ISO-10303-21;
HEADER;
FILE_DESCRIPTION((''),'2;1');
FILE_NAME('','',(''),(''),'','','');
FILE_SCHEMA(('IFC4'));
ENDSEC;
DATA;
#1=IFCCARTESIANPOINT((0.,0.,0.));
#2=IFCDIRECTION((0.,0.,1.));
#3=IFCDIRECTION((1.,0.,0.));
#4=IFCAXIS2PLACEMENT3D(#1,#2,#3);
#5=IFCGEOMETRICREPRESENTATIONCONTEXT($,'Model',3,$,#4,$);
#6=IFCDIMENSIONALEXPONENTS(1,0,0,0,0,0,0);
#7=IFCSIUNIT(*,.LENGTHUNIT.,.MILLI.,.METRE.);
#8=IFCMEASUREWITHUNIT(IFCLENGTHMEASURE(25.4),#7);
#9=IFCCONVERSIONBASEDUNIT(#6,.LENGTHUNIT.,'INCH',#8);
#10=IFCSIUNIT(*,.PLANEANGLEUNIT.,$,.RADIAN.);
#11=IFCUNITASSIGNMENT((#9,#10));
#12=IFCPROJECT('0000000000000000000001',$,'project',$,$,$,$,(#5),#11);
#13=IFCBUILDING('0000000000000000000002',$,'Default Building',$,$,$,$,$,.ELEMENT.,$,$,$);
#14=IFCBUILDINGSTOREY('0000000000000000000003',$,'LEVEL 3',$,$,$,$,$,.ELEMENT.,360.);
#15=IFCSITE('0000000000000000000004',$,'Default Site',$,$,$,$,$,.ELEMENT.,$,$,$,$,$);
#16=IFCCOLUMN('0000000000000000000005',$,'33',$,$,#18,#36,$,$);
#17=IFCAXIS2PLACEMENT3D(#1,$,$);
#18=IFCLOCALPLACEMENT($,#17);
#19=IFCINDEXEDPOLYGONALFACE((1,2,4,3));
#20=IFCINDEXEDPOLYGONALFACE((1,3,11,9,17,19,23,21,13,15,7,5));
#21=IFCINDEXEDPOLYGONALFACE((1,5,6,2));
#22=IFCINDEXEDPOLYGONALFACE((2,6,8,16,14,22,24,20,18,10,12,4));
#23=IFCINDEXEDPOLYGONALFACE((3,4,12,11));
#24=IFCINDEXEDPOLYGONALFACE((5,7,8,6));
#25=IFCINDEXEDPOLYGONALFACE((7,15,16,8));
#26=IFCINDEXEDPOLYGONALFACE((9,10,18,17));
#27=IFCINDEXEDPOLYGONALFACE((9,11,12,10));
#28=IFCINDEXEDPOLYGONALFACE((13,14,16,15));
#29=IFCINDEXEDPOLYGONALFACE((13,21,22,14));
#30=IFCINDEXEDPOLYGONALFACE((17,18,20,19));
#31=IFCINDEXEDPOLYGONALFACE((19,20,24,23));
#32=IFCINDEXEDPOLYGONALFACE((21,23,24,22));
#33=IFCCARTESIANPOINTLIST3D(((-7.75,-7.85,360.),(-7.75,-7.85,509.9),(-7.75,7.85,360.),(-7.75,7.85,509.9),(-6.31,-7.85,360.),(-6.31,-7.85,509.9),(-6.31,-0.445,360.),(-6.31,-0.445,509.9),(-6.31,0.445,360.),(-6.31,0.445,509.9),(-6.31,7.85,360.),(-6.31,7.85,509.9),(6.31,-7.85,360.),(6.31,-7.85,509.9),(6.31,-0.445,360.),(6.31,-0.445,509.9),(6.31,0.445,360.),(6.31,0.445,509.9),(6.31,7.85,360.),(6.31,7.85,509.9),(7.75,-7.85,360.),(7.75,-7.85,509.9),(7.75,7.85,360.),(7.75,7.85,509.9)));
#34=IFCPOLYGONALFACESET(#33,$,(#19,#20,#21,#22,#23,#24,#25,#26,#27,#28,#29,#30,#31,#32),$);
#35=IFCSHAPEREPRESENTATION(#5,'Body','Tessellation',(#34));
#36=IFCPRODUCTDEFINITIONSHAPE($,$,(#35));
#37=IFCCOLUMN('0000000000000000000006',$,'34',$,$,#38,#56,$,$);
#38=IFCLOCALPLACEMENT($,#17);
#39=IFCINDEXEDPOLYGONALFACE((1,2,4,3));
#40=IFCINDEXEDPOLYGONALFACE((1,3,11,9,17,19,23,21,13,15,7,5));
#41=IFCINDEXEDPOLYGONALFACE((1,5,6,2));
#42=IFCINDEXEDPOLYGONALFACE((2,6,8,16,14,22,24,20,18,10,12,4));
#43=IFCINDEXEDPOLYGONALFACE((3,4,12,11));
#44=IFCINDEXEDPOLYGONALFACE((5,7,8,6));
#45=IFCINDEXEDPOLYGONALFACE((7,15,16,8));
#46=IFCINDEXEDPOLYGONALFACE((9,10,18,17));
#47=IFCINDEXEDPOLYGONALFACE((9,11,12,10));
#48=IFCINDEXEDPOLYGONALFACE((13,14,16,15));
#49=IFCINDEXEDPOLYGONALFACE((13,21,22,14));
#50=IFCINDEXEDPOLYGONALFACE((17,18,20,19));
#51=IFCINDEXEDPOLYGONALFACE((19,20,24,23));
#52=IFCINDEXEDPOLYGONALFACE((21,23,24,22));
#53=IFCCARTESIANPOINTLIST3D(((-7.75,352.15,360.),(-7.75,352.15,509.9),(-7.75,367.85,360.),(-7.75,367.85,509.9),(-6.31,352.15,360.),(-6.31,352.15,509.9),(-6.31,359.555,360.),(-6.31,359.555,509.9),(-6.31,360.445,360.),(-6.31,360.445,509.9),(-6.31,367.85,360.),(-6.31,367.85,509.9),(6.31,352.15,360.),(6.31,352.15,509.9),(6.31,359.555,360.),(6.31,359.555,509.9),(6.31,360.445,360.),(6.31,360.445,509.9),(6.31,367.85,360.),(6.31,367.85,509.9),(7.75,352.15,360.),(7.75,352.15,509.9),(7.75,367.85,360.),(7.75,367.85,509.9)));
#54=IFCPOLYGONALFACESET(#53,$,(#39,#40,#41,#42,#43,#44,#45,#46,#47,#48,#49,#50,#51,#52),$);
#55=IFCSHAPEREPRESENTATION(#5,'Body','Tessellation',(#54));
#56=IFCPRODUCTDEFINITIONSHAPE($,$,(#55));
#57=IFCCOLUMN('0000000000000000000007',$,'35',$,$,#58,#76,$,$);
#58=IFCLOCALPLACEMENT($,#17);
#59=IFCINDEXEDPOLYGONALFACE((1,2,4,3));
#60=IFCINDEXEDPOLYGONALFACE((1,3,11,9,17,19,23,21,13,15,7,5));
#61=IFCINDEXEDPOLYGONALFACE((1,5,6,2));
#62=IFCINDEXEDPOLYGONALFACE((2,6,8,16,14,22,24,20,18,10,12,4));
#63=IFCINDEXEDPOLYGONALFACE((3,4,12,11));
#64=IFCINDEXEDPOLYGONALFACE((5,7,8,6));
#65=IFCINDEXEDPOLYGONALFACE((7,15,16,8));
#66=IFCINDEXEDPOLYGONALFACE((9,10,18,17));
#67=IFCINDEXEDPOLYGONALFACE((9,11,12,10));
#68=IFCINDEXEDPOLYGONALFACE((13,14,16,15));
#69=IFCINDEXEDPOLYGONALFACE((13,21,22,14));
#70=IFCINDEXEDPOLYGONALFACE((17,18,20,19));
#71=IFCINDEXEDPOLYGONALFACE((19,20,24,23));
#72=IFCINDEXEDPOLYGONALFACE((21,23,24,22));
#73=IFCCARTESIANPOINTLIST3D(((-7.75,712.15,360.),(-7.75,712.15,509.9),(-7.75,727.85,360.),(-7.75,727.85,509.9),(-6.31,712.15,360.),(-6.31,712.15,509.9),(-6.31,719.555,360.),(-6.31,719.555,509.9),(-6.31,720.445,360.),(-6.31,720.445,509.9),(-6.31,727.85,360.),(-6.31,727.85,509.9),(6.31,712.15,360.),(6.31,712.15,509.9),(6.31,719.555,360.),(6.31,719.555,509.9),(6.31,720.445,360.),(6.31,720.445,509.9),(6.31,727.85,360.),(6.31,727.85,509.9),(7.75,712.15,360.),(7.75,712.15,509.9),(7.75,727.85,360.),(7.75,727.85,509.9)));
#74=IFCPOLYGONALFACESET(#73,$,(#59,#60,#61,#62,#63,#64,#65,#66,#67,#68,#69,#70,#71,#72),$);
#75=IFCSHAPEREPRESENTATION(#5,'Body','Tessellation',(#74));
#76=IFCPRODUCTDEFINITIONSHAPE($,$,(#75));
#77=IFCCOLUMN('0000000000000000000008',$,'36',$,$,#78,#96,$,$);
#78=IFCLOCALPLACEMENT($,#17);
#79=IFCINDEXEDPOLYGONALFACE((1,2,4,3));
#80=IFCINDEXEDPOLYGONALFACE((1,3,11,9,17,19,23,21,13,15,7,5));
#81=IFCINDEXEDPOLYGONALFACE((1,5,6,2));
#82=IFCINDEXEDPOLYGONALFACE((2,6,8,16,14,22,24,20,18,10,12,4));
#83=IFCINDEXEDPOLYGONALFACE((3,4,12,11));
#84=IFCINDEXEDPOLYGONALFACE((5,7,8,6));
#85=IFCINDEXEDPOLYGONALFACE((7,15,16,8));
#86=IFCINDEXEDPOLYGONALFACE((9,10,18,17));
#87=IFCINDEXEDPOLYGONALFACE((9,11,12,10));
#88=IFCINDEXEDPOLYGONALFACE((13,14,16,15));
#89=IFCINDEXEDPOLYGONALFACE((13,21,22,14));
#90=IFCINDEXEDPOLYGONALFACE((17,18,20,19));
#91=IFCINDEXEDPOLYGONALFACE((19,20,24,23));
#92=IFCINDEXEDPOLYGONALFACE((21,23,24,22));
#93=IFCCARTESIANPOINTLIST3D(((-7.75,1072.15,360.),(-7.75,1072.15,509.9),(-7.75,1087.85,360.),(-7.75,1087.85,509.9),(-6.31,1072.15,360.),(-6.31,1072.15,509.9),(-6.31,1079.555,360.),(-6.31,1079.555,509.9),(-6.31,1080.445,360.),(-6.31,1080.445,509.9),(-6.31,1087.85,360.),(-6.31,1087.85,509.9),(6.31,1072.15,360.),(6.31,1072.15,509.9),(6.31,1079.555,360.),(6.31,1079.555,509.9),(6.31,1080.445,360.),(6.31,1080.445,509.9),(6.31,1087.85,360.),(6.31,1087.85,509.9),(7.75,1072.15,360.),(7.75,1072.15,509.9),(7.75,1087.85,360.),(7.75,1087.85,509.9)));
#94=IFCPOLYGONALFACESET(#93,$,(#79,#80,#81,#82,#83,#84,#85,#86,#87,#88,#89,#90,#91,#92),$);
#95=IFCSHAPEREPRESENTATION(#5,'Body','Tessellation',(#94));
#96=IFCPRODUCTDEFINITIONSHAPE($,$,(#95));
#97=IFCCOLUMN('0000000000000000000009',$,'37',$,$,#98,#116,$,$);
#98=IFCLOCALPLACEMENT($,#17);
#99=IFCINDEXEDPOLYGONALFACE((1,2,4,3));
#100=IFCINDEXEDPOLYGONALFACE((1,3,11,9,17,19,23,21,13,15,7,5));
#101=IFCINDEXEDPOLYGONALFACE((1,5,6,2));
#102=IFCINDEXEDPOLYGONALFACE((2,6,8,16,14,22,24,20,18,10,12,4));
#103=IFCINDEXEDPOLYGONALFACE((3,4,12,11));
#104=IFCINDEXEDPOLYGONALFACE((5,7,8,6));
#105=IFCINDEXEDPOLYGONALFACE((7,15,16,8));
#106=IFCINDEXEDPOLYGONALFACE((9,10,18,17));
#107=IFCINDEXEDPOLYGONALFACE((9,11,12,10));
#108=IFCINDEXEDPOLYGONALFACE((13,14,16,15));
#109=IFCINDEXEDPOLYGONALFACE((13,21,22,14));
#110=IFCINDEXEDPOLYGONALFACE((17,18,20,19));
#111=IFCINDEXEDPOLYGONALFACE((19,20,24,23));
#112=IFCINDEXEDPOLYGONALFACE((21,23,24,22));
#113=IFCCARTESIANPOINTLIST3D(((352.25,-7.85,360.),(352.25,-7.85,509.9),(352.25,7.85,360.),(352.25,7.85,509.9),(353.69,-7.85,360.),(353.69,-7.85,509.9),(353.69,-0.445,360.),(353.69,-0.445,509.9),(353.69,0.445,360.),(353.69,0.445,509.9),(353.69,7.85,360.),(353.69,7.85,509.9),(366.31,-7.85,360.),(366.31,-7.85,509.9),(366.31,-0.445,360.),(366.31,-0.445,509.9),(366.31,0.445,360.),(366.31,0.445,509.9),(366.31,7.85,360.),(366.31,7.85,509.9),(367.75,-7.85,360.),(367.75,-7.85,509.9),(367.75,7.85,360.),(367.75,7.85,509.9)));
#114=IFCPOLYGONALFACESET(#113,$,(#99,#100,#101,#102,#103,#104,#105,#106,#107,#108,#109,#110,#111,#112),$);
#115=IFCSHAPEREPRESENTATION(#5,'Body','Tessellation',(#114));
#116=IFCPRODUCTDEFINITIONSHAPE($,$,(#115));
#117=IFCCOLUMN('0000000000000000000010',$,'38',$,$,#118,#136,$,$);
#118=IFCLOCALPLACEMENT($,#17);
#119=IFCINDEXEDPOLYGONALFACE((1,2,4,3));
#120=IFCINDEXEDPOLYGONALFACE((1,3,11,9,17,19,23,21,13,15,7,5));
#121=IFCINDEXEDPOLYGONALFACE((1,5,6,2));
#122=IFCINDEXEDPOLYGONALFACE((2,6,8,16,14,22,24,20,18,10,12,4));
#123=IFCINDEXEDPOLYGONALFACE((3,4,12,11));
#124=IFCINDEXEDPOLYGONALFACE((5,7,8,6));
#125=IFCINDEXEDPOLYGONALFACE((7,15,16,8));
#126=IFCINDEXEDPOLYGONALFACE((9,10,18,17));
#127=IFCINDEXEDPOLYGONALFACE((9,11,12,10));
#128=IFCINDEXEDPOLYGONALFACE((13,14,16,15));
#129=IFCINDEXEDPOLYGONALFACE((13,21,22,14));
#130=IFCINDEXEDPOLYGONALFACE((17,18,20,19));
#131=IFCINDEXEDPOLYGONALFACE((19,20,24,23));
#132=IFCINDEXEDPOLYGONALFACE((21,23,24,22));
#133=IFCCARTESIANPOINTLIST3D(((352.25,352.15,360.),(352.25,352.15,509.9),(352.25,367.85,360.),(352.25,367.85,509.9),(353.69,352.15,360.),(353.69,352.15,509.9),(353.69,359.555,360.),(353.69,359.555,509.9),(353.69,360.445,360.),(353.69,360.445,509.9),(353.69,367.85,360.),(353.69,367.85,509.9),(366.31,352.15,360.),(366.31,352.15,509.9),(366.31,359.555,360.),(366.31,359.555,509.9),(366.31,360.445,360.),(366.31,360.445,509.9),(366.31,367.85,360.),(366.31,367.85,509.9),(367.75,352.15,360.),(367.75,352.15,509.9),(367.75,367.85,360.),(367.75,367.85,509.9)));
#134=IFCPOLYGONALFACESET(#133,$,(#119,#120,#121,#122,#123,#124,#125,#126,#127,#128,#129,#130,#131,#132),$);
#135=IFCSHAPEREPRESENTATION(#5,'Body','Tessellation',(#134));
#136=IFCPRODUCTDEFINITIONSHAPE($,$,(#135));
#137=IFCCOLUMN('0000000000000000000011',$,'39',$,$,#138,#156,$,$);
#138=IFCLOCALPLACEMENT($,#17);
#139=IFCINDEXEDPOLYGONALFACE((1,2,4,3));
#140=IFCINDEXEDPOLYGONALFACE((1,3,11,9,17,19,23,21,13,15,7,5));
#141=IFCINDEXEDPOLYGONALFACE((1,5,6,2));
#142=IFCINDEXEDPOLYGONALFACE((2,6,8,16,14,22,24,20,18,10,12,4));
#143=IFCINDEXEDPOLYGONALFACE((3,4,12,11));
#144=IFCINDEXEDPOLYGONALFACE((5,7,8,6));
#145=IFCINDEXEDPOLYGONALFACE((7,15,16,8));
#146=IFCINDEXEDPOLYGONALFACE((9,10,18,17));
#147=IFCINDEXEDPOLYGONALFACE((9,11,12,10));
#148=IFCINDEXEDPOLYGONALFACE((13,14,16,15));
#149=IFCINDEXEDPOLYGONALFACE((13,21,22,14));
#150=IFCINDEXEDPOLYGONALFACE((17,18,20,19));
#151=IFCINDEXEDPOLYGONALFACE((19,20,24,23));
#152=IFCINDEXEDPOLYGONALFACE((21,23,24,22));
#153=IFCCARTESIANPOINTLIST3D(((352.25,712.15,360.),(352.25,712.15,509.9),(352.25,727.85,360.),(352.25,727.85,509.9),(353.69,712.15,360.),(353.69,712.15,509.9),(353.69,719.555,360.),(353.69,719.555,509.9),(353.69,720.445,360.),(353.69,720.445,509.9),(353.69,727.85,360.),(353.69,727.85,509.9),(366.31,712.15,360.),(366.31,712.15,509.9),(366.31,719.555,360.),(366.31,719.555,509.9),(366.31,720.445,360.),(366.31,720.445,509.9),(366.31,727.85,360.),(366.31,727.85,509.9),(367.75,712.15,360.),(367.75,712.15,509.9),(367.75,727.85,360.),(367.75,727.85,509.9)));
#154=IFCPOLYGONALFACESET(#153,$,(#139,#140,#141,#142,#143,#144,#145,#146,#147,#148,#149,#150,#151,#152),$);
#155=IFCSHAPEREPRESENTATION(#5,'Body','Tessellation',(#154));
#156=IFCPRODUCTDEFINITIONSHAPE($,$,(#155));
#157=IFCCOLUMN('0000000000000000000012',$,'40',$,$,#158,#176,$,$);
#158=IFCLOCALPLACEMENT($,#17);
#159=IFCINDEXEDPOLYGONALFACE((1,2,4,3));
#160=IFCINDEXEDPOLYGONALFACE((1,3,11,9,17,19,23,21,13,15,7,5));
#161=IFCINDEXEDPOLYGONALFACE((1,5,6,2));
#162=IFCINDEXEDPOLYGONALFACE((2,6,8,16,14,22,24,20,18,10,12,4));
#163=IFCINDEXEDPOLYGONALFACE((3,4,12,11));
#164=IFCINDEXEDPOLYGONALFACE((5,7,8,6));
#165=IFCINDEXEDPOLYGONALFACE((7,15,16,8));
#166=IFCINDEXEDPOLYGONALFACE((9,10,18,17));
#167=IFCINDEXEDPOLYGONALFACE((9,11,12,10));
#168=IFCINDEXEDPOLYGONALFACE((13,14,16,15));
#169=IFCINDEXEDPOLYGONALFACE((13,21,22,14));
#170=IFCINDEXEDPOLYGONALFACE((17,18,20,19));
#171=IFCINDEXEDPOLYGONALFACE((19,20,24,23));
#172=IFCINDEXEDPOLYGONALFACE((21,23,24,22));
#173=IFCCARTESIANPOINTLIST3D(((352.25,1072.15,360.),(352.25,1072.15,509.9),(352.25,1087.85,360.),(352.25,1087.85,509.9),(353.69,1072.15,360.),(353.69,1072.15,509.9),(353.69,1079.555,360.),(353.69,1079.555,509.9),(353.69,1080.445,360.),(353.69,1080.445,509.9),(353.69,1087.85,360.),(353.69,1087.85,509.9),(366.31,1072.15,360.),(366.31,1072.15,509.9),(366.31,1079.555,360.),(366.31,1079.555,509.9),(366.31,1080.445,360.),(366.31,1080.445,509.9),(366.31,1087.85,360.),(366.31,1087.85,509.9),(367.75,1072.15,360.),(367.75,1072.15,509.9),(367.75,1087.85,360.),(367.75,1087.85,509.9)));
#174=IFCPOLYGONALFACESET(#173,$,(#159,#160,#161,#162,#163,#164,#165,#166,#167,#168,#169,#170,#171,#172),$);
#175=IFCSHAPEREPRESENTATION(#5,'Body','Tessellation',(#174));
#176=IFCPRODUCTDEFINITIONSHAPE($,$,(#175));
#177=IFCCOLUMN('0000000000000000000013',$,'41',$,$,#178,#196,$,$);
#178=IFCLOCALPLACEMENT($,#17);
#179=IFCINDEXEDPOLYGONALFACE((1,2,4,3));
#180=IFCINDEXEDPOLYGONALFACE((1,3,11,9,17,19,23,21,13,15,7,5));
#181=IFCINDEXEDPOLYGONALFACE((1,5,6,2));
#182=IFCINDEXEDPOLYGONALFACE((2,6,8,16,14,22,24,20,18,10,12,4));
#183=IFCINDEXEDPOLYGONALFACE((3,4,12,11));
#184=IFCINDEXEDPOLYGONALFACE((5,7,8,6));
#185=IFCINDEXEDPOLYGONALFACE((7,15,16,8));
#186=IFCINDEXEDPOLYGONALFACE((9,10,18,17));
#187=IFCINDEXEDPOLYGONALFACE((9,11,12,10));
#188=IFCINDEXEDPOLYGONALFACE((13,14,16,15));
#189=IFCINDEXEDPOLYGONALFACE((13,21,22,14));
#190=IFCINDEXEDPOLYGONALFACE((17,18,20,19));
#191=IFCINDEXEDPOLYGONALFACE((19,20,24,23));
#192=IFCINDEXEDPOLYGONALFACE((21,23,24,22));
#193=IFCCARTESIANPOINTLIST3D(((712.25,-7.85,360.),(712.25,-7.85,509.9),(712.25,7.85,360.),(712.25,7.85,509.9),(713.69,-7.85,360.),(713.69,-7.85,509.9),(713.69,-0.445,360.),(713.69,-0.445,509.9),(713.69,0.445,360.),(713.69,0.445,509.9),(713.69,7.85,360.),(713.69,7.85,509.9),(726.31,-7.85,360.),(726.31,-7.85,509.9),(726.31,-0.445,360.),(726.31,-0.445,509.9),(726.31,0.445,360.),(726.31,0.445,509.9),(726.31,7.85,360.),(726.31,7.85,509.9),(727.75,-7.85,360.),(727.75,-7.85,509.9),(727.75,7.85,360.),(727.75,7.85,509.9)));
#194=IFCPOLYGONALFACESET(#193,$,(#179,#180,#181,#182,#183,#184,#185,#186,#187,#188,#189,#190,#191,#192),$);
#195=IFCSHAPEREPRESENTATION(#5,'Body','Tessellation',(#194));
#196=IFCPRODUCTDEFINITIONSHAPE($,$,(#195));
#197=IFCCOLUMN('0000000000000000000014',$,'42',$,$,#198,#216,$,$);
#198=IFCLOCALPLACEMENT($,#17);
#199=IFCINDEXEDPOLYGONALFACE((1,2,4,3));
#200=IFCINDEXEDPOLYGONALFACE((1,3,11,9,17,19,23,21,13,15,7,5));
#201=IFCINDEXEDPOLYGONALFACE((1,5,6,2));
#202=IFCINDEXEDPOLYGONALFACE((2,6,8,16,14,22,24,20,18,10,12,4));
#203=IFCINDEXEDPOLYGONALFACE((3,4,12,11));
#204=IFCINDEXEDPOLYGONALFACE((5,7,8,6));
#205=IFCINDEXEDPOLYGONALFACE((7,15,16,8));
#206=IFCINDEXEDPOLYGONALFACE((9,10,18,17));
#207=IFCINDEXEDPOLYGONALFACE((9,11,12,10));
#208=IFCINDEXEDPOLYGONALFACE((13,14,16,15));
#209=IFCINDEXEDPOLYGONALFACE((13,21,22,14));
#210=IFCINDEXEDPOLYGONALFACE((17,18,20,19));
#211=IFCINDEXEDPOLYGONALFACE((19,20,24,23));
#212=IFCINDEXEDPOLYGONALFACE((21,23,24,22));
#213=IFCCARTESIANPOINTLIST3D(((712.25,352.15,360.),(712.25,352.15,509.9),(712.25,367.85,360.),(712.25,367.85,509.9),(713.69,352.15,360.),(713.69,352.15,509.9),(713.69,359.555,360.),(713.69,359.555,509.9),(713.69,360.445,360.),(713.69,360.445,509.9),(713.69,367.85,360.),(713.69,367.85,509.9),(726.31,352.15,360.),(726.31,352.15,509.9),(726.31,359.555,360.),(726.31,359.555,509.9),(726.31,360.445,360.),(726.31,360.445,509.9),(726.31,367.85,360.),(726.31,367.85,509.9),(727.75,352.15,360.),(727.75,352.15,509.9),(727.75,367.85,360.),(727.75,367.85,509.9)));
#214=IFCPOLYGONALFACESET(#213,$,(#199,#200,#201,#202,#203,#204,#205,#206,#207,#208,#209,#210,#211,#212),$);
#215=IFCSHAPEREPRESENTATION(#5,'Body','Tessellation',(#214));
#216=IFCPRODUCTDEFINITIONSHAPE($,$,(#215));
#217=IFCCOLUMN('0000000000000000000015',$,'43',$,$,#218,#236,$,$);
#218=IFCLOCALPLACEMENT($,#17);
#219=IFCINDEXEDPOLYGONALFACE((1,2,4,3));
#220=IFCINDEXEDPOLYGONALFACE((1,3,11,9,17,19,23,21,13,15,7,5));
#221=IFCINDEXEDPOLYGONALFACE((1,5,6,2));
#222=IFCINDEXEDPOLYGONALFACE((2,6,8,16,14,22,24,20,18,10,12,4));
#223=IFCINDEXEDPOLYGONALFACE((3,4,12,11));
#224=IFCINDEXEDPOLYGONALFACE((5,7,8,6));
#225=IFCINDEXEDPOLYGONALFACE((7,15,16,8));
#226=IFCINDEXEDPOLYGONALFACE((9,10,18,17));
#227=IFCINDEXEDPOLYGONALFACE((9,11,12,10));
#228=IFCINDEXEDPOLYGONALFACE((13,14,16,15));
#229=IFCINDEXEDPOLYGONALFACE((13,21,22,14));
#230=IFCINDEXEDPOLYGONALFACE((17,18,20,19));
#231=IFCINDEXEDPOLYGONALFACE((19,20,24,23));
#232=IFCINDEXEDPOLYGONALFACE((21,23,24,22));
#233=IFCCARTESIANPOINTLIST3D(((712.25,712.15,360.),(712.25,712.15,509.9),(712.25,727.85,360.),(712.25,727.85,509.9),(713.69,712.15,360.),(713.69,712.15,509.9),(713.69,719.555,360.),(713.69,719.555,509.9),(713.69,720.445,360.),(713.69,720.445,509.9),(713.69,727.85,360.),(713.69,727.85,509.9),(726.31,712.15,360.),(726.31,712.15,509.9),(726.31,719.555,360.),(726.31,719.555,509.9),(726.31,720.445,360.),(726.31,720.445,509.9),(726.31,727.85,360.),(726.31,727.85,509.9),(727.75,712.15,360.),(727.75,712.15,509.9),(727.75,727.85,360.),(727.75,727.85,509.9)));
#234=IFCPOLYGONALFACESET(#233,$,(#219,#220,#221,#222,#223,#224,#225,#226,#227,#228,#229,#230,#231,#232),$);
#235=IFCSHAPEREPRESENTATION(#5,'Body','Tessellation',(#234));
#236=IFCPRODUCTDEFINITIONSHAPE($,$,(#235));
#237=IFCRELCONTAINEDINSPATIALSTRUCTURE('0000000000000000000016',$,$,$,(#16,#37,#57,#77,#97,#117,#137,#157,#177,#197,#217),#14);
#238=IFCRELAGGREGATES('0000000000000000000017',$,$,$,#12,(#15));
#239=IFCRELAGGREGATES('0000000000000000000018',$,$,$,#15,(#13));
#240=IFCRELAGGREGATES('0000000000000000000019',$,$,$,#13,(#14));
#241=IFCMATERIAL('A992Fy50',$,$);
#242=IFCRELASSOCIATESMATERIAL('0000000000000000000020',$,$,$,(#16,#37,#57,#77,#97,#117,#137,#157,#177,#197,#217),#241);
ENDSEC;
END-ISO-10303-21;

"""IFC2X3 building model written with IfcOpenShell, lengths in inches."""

from ifc_helpers import new_model, entity, si_unit, converted_unit, frame, origin_with_axes, origin_2d_with_axis, place, context, project, spatial, i_section, extrude, material, element, save


model = new_model("IFC2X3")

# Units and contexts
model_context = context("Model", 3, world=origin_with_axes())
ifc_project = project(units=[converted_unit("LENGTHUNIT", "INCH", entity("IfcLengthMeasure", 25.4), si_unit("LENGTHUNIT", "METRE", prefix="MILLI"), dimensions=[1, 0, 0, 0, 0, 0, 0]), si_unit("PLANEANGLEUNIT", "RADIAN")], contexts=[model_context])

# Site, building, storey
site = spatial("IfcSite", under=ifc_project, Name="Default Site", CompositionType="ELEMENT")
building = spatial("IfcBuilding", under=site, Name="Default Building", CompositionType="ELEMENT")
storey = spatial("IfcBuildingStorey", under=building, Name="LEVEL 3", CompositionType="ELEMENT", Elevation=360.0)

# Columns
ifc_material = material(Name="A992Fy50")
for number, where, z_axis, x_axis, name in (
    (1, (0.0, 0.0, 360.0), (0.0, 0.0, 1.0), (0.0, -1.0, 0.0), "33"),
    (2, (0.0, 360.0, 360.0), (0.0, 0.0, 1.0), (0.0, -1.0, 0.0), "34"),
    (3, (0.0, 720.0, 360.0), (0.0, 0.0, 1.0), (0.0, -1.0, 0.0), "35"),
    (4, (0.0, 1080.0, 360.0), (0.0, 0.0, 1.0), (0.0, -1.0, 0.0), "36"),
    (5, (360.0, 0.0, 360.0), (0.0, 0.0, 1.0), (0.0, -1.0, 0.0), "37"),
    (6, (360.0, 360.0, 360.0), (0.0, 0.0, 1.0), (0.0, -1.0, 0.0), "38"),
    (7, (360.0, 720.0, 360.0), (0.0, 0.0, 1.0), (0.0, -1.0, 0.0), "39"),
    (8, (360.0, 1080.0, 360.0), (0.0, 0.0, 1.0), (0.0, -1.0, 0.0), "40"),
    (9, (720.0, 0.0, 360.0), (0.0, 0.0, 1.0), (0.0, -1.0, 0.0), "41"),
    (10, (720.0, 360.0, 360.0), (0.0, 0.0, 1.0), (0.0, -1.0, 0.0), "42"),
    (11, (720.0, 720.0, 360.0), (0.0, 0.0, 1.0), (0.0, -1.0, 0.0), "43"),
):
    element("IfcColumn", number, at=place(None, frame(where, z_axis=z_axis, x_axis=x_axis)), inside=storey, material=ifc_material, Name=name, context=model_context, shape_type="SweptSolid", body=[
        extrude(i_section(OverallWidth=15.7, OverallDepth=15.5, WebThickness=0.89, FlangeThickness=1.44, at=origin_2d_with_axis()), origin_with_axes(), (0.0, 0.0, 1.0), 149.9),
    ])

save(model, "model.ifc")
